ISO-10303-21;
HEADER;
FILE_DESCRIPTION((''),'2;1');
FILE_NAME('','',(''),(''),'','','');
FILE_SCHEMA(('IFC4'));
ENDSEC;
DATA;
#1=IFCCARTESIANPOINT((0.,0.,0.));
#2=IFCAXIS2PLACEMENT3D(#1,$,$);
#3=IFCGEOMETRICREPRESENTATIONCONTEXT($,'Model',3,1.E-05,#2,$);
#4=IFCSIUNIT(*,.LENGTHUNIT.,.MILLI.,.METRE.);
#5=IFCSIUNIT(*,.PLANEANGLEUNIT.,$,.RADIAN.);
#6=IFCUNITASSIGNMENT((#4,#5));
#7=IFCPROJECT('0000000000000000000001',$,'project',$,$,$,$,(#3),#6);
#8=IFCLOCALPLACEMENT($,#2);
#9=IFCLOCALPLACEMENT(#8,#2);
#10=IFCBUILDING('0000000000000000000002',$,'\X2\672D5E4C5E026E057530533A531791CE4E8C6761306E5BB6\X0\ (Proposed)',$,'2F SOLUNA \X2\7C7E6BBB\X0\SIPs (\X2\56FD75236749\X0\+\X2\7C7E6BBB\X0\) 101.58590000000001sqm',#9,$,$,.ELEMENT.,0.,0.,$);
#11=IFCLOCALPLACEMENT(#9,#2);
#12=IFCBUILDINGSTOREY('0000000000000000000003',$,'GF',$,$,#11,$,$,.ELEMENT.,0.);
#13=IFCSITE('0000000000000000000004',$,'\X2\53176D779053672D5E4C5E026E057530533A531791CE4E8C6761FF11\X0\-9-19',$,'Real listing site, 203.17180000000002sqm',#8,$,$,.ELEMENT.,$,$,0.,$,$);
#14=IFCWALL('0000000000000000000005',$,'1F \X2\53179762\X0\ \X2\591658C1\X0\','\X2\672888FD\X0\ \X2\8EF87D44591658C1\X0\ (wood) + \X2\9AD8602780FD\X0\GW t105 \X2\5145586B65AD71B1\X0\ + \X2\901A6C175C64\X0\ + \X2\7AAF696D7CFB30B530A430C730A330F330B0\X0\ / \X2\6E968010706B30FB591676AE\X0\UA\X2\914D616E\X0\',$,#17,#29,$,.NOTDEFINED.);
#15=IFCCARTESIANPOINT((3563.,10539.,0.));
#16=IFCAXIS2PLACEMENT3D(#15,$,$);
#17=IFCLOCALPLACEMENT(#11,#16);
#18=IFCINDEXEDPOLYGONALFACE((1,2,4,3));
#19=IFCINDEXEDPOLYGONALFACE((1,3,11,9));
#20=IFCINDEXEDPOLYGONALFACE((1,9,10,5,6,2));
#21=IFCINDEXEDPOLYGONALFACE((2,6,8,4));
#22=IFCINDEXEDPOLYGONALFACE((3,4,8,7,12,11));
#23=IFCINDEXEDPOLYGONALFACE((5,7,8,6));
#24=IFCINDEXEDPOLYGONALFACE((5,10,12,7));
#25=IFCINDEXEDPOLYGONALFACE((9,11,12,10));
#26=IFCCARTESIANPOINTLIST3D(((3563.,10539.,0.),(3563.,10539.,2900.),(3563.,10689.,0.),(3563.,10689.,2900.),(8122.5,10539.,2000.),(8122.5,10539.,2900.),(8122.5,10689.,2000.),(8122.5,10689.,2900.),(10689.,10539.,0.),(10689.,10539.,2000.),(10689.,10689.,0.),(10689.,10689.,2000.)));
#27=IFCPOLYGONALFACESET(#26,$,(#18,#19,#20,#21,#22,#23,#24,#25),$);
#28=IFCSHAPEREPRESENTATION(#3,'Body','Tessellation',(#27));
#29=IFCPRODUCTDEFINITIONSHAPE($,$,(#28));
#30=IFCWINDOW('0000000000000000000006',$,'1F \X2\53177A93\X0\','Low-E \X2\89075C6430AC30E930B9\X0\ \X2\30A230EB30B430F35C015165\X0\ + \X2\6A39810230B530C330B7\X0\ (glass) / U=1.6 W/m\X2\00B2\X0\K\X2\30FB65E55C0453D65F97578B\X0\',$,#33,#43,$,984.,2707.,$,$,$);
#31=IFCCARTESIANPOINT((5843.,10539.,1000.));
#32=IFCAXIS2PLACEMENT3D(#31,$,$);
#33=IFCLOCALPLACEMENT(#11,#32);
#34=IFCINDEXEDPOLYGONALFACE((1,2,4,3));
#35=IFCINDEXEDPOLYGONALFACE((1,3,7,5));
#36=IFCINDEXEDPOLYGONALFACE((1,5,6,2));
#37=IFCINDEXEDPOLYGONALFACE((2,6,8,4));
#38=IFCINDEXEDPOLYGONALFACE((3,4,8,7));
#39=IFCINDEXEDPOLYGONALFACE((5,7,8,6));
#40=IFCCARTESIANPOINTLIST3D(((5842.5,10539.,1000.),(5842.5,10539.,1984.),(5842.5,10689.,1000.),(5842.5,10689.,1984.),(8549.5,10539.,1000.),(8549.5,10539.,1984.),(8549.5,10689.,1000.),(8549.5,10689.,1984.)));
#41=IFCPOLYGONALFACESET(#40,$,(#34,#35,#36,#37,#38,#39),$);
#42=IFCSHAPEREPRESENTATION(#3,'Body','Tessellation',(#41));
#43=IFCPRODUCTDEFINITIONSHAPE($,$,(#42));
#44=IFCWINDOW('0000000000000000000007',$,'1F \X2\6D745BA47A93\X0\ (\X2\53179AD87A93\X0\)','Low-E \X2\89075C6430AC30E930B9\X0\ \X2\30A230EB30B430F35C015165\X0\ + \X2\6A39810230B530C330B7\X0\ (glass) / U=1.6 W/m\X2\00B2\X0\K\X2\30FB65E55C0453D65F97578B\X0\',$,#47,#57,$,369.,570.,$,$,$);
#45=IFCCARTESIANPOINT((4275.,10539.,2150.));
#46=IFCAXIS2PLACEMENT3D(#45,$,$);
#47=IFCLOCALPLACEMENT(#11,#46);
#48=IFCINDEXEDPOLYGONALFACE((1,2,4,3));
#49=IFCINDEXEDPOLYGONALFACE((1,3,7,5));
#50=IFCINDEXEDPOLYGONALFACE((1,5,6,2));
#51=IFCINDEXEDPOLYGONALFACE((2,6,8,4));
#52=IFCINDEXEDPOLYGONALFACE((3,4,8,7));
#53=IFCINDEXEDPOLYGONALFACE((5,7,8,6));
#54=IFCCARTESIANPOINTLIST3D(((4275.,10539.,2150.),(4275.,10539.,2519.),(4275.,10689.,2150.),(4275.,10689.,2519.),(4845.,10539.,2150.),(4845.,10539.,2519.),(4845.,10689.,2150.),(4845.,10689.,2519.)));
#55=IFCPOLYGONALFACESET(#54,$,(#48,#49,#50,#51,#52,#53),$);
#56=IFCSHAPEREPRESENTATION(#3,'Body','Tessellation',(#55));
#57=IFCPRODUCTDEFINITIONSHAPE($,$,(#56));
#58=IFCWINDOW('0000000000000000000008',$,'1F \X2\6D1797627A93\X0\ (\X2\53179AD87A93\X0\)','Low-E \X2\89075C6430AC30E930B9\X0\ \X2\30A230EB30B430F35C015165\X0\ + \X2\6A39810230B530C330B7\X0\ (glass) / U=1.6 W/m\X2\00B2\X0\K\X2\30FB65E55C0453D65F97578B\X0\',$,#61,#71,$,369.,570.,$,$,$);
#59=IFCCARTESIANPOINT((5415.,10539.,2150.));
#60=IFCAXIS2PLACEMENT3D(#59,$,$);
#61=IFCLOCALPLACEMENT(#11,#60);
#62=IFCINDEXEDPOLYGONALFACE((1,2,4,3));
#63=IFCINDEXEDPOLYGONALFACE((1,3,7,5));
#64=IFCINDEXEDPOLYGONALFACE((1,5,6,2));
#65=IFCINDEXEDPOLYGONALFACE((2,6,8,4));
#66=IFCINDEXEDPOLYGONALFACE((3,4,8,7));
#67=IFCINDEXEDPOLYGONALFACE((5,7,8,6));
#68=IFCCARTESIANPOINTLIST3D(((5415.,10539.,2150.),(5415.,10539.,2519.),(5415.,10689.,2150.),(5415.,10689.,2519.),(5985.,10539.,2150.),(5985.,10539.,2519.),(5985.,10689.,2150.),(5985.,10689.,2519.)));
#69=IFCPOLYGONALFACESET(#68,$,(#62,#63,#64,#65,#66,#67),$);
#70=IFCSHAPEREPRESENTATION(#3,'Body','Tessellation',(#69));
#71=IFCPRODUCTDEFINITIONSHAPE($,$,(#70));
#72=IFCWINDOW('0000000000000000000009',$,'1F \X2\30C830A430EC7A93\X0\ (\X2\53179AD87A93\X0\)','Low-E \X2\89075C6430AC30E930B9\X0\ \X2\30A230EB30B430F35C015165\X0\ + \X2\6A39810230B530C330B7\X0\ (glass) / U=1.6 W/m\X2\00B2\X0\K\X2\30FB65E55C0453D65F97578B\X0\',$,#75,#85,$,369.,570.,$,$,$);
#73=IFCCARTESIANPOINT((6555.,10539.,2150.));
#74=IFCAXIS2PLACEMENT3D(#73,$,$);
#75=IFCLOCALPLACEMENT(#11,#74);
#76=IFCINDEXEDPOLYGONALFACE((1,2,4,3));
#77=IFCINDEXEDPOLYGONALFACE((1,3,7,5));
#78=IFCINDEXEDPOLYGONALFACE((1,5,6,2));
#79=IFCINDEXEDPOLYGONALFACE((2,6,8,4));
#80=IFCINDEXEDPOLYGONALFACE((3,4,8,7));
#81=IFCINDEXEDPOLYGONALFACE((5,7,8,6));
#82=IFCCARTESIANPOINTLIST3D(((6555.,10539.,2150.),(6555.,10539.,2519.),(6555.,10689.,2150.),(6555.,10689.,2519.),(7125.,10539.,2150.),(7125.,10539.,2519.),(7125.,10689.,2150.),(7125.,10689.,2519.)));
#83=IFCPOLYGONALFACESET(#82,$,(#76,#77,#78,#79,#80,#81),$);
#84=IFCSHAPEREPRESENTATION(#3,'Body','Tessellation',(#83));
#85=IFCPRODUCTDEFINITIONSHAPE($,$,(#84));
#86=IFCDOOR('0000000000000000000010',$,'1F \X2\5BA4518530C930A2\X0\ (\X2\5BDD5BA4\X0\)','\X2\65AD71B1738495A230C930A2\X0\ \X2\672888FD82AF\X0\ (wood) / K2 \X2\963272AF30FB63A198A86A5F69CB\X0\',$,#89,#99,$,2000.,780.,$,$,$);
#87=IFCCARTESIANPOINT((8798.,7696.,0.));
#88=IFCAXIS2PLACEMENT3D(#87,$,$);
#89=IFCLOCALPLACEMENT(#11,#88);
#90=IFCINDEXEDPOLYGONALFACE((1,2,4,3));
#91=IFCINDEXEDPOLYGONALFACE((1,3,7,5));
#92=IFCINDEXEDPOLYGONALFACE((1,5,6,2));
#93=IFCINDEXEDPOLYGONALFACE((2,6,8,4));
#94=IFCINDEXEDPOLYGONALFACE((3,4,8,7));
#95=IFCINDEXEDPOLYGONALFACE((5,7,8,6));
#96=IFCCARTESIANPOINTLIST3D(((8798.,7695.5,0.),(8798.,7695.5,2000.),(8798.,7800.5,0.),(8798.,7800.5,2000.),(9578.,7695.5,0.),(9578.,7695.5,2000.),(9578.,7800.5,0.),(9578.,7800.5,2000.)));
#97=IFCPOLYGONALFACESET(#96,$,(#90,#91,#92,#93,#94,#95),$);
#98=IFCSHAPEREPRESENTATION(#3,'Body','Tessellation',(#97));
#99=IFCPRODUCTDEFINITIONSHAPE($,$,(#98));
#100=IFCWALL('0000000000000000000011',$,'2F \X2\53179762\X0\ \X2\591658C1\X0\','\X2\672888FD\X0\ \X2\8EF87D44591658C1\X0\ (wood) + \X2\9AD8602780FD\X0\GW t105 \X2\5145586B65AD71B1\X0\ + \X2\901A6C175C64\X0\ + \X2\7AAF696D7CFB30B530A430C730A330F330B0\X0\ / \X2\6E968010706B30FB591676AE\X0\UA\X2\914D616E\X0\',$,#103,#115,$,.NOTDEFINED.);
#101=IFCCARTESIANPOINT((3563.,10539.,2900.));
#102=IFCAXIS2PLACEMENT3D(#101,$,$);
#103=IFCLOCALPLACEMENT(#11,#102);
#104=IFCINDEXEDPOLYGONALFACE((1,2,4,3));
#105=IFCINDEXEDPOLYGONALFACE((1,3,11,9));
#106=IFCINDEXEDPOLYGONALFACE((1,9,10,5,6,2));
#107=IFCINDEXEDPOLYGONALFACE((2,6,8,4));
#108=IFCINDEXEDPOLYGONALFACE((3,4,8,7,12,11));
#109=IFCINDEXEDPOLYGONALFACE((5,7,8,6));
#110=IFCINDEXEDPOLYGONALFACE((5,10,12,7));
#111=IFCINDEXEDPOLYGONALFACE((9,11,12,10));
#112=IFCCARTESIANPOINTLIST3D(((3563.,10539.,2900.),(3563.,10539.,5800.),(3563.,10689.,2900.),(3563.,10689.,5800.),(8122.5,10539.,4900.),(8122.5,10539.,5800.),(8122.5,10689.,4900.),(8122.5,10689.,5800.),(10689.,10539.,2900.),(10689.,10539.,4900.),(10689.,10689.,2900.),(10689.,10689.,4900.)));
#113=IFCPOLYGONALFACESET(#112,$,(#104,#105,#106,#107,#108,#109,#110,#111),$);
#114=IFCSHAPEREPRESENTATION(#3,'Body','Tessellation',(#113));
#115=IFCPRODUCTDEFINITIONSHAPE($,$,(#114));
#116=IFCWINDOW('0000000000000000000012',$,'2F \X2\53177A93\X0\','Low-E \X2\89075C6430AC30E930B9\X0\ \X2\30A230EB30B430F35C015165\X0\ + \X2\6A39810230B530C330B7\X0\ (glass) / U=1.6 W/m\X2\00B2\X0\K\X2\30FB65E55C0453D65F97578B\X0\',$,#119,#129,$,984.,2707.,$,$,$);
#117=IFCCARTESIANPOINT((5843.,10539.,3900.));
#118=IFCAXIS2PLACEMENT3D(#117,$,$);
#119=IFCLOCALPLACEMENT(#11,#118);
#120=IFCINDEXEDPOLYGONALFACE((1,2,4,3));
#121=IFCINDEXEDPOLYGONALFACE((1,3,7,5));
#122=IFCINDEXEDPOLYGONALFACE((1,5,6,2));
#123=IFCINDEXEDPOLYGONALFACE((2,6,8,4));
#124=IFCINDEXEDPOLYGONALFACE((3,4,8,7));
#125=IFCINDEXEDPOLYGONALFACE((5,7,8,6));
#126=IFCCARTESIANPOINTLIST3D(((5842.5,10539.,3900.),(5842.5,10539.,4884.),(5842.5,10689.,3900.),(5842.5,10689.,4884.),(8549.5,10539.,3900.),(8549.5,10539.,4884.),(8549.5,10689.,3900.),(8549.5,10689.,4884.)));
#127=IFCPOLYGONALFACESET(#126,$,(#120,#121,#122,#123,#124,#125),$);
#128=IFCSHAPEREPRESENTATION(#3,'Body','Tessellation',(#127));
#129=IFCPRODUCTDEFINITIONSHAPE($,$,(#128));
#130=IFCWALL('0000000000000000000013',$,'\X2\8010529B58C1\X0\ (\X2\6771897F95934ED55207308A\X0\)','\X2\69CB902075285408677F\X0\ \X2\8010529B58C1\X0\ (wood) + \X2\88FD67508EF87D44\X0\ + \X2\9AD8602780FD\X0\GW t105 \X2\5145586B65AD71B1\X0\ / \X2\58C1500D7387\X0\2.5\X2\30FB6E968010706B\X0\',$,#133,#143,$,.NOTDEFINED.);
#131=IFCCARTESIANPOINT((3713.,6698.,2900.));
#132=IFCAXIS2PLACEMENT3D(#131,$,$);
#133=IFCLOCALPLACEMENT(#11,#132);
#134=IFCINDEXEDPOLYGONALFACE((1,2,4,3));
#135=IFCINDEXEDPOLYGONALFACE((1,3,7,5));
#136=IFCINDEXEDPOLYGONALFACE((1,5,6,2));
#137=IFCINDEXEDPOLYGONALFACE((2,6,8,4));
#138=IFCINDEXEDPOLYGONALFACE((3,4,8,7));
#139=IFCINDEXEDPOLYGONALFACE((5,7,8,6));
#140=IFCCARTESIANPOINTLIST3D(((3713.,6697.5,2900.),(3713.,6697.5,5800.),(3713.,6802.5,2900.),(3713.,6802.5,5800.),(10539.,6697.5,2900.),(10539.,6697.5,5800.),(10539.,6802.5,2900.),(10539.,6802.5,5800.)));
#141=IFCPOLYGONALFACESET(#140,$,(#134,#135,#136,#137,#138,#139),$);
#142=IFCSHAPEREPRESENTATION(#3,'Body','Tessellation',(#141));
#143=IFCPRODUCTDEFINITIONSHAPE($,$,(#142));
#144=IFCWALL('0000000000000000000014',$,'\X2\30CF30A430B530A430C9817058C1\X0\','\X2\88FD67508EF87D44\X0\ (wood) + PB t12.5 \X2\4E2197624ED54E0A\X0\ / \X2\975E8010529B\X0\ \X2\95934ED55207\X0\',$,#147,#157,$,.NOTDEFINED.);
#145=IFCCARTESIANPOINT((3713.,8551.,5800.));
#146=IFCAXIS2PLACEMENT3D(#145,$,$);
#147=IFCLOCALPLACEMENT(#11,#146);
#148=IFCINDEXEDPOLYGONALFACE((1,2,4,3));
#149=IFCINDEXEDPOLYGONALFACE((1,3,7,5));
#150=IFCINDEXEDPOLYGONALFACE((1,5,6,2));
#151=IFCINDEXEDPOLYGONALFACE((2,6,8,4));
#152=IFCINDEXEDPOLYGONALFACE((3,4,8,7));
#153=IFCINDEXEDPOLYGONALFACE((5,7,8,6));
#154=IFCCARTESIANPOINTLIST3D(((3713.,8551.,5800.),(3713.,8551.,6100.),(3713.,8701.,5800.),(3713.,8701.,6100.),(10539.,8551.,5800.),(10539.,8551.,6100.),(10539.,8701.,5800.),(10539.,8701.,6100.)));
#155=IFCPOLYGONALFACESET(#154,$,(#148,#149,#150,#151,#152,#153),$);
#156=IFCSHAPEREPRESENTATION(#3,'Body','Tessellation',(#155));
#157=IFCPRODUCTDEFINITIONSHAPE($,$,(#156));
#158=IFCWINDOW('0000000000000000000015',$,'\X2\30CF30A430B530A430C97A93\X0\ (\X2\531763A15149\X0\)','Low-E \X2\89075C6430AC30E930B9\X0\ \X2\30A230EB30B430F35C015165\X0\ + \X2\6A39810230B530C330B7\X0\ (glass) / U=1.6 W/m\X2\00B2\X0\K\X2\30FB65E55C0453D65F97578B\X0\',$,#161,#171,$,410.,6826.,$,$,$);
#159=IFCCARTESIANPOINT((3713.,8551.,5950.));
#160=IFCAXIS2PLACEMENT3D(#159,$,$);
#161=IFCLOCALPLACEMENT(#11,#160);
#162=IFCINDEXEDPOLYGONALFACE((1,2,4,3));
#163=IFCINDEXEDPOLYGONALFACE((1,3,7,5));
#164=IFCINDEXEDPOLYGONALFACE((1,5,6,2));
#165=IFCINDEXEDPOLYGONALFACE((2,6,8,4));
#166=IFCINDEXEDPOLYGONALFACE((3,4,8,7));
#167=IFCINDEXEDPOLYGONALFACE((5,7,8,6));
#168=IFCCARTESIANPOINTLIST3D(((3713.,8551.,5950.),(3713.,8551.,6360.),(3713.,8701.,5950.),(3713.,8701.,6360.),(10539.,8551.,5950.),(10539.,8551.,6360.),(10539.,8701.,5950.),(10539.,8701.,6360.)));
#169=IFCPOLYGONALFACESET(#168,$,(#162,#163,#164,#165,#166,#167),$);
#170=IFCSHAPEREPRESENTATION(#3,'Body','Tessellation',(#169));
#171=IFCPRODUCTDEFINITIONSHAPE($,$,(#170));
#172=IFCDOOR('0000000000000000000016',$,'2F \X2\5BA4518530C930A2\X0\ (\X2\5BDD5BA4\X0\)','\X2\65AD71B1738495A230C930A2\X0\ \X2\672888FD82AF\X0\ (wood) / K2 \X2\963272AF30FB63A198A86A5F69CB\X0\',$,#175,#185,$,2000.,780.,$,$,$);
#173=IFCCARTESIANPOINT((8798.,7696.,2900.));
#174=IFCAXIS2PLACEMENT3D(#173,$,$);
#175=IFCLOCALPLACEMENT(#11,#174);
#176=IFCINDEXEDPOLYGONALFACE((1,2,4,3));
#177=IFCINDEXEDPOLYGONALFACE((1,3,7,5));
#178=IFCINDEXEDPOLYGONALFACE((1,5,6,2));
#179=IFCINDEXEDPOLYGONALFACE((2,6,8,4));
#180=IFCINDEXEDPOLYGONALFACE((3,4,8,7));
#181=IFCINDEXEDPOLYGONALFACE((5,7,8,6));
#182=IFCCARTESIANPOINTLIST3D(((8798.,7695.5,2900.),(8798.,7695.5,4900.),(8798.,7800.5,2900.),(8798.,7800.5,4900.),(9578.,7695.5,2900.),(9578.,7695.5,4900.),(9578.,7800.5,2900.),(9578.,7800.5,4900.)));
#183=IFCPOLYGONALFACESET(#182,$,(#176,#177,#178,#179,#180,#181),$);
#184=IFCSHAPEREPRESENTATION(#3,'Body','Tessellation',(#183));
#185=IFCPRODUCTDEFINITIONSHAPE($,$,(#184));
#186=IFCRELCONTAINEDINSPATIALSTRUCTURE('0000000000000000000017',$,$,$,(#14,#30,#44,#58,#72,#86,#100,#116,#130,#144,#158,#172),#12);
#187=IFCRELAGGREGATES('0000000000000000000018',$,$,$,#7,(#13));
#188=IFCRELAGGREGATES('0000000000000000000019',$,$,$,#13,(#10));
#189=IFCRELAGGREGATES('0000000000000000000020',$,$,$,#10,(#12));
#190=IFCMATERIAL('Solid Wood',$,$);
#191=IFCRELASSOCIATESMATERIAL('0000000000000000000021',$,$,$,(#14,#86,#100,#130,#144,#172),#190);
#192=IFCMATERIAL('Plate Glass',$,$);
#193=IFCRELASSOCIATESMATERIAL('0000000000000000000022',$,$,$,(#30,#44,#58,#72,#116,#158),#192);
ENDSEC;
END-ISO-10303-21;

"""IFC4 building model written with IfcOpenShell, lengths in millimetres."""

from ifc_helpers import new_model, si_unit, frame, frame_2d, origin, place, context, project, spatial, rectangle, extrude, material, element, fill, save


model = new_model("IFC4")

# Units and contexts
model_context = context("Model", 3, precision=1e-05, world=origin())
ifc_project = project(units=[si_unit("LENGTHUNIT", "METRE", prefix="MILLI"), si_unit("PLANEANGLEUNIT", "RADIAN")], contexts=[model_context])

# Site, building, storey
site_placement = place(None, origin())
site = spatial("IfcSite", under=ifc_project, at=site_placement, Name="北海道札幌市清田区北野二条１-9-19", ObjectType="Real listing site, 203.17180000000002sqm", CompositionType="ELEMENT", RefElevation=0.0)
building_placement = place(site_placement, origin())
building = spatial("IfcBuilding", under=site, at=building_placement, Name="札幌市清田区北野二条の家 (Proposed)", ObjectType="2F SOLUNA 籾殻SIPs (国産杉+籾殻) 101.58590000000001sqm", CompositionType="ELEMENT", ElevationOfRefHeight=0.0, ElevationOfTerrain=0.0)
storey_placement = place(building_placement, origin())
storey = spatial("IfcBuildingStorey", under=building, at=storey_placement, Name="GF", CompositionType="ELEMENT", Elevation=0.0)

# Wall, openings, windows
ifc_material_1 = material(Name="Solid Wood")
wall_1_placement = place(storey_placement, frame((3563.0, 10539.0, 0.0)))
wall_1 = element("IfcWall", 1, at=wall_1_placement, inside=storey, material=ifc_material_1, Name="1F 北面 外壁", Description="木製 軸組外壁 (wood) + 高性能GW t105 充填断熱 + 通気層 + 窯業系サイディング / 準耐火・外皮UA配慮", PredefinedType="NOTDEFINED", context=model_context, shape_type="SweptSolid", body=[
    extrude(rectangle(XDim=7126.0, YDim=150.0, at=frame_2d((3563.0, 75.0))), frame((3563.0, 10539.0, 0.0)), (0.0, 0.0, 1.0), 2900.0),
])
opening_1_placement = place(storey_placement, frame((5843.0, 10539.0, 1000.0)))
opening_1 = element("IfcOpeningElement", 2, at=opening_1_placement, cuts=wall_1, PredefinedType="NOTDEFINED", context=model_context, shape_type="SweptSolid", body=[
    extrude(rectangle(XDim=2707.0, YDim=150.0, at=frame_2d((1353.0, 75.0))), frame((5843.0, 10539.0, 1000.0)), (0.0, 0.0, 1.0), 984.0),
])
opening_2_placement = place(storey_placement, frame((4275.0, 10539.0, 2150.0)))
opening_2 = element("IfcOpeningElement", 3, at=opening_2_placement, cuts=wall_1, PredefinedType="NOTDEFINED", context=model_context, shape_type="SweptSolid", body=[
    extrude(rectangle(XDim=570.0, YDim=150.0, at=frame_2d((285.0, 75.0))), frame((4275.0, 10539.0, 2150.0)), (0.0, 0.0, 1.0), 369.0),
])
opening_3_placement = place(storey_placement, frame((5415.0, 10539.0, 2150.0)))
opening_3 = element("IfcOpeningElement", 4, at=opening_3_placement, cuts=wall_1, PredefinedType="NOTDEFINED", context=model_context, shape_type="SweptSolid", body=[
    extrude(rectangle(XDim=570.0, YDim=150.0, at=frame_2d((285.0, 75.0))), frame((5415.0, 10539.0, 2150.0)), (0.0, 0.0, 1.0), 369.0),
])
opening_4_placement = place(storey_placement, frame((6555.0, 10539.0, 2150.0)))
opening_4 = element("IfcOpeningElement", 5, at=opening_4_placement, cuts=wall_1, PredefinedType="NOTDEFINED", context=model_context, shape_type="SweptSolid", body=[
    extrude(rectangle(XDim=570.0, YDim=150.0, at=frame_2d((285.0, 75.0))), frame((6555.0, 10539.0, 2150.0)), (0.0, 0.0, 1.0), 369.0),
])
ifc_material_2 = material(Name="Plate Glass")
window_1_placement = place(storey_placement, frame((5843.0, 10539.0, 1000.0)))
window_1 = element("IfcWindow", 6, at=window_1_placement, inside=storey, material=ifc_material_2, Name="1F 北窓", Description="Low-E 複層ガラス アルゴン封入 + 樹脂サッシ (glass) / U=1.6 W/m²K・日射取得型", OverallHeight=984.0, OverallWidth=2707.0, context=model_context, shape_type="SweptSolid", body=[
    extrude(rectangle(XDim=2707.0, YDim=150.0, at=frame_2d((1353.0, 75.0))), frame((5843.0, 10539.0, 1000.0)), (0.0, 0.0, 1.0), 984.0),
])
fill(opening_1, window_1)
window_2_placement = place(storey_placement, frame((4275.0, 10539.0, 2150.0)))
window_2 = element("IfcWindow", 7, at=window_2_placement, inside=storey, material=ifc_material_2, Name="1F 浴室窓 (北高窓)", Description="Low-E 複層ガラス アルゴン封入 + 樹脂サッシ (glass) / U=1.6 W/m²K・日射取得型", OverallHeight=369.0, OverallWidth=570.0, context=model_context, shape_type="SweptSolid", body=[
    extrude(rectangle(XDim=570.0, YDim=150.0, at=frame_2d((285.0, 75.0))), frame((4275.0, 10539.0, 2150.0)), (0.0, 0.0, 1.0), 369.0),
])
fill(opening_2, window_2)
window_3_placement = place(storey_placement, frame((5415.0, 10539.0, 2150.0)))
window_3 = element("IfcWindow", 8, at=window_3_placement, inside=storey, material=ifc_material_2, Name="1F 洗面窓 (北高窓)", Description="Low-E 複層ガラス アルゴン封入 + 樹脂サッシ (glass) / U=1.6 W/m²K・日射取得型", OverallHeight=369.0, OverallWidth=570.0, context=model_context, shape_type="SweptSolid", body=[
    extrude(rectangle(XDim=570.0, YDim=150.0, at=frame_2d((285.0, 75.0))), frame((5415.0, 10539.0, 2150.0)), (0.0, 0.0, 1.0), 369.0),
])
fill(opening_3, window_3)
window_4_placement = place(storey_placement, frame((6555.0, 10539.0, 2150.0)))
window_4 = element("IfcWindow", 9, at=window_4_placement, inside=storey, material=ifc_material_2, Name="1F トイレ窓 (北高窓)", Description="Low-E 複層ガラス アルゴン封入 + 樹脂サッシ (glass) / U=1.6 W/m²K・日射取得型", OverallHeight=369.0, OverallWidth=570.0, context=model_context, shape_type="SweptSolid", body=[
    extrude(rectangle(XDim=570.0, YDim=150.0, at=frame_2d((285.0, 75.0))), frame((6555.0, 10539.0, 2150.0)), (0.0, 0.0, 1.0), 369.0),
])
fill(opening_4, window_4)

# Door
door_1_placement = place(storey_placement, frame((8798.0, 7696.0, 0.0)))
element("IfcDoor", 10, at=door_1_placement, inside=storey, material=ifc_material_1, Name="1F 室内ドア (寝室)", Description="断熱玄関ドア 木製芯 (wood) / K2 防犯・採風機構", OverallHeight=2000.0, OverallWidth=780.0, context=model_context, shape_type="SweptSolid", body=[
    extrude(rectangle(XDim=780.0, YDim=105.0, at=frame_2d((390.0, 52.0))), frame((8798.0, 7696.0, 0.0)), (0.0, 0.0, 1.0), 2000.0),
])

# Wall, opening, window
wall_2_placement = place(storey_placement, frame((3563.0, 10539.0, 2900.0)))
wall_2 = element("IfcWall", 11, at=wall_2_placement, inside=storey, material=ifc_material_1, Name="2F 北面 外壁", Description="木製 軸組外壁 (wood) + 高性能GW t105 充填断熱 + 通気層 + 窯業系サイディング / 準耐火・外皮UA配慮", PredefinedType="NOTDEFINED", context=model_context, shape_type="SweptSolid", body=[
    extrude(rectangle(XDim=7126.0, YDim=150.0, at=frame_2d((3563.0, 75.0))), frame((3563.0, 10539.0, 2900.0)), (0.0, 0.0, 1.0), 2900.0),
])
opening_5_placement = place(storey_placement, frame((5843.0, 10539.0, 3900.0)))
opening_5 = element("IfcOpeningElement", 12, at=opening_5_placement, cuts=wall_2, PredefinedType="NOTDEFINED", context=model_context, shape_type="SweptSolid", body=[
    extrude(rectangle(XDim=2707.0, YDim=150.0, at=frame_2d((1353.0, 75.0))), frame((5843.0, 10539.0, 3900.0)), (0.0, 0.0, 1.0), 984.0),
])
window_5_placement = place(storey_placement, frame((5843.0, 10539.0, 3900.0)))
window_5 = element("IfcWindow", 13, at=window_5_placement, inside=storey, material=ifc_material_2, Name="2F 北窓", Description="Low-E 複層ガラス アルゴン封入 + 樹脂サッシ (glass) / U=1.6 W/m²K・日射取得型", OverallHeight=984.0, OverallWidth=2707.0, context=model_context, shape_type="SweptSolid", body=[
    extrude(rectangle(XDim=2707.0, YDim=150.0, at=frame_2d((1353.0, 75.0))), frame((5843.0, 10539.0, 3900.0)), (0.0, 0.0, 1.0), 984.0),
])
fill(opening_5, window_5)

# Wall
wall_3_placement = place(storey_placement, frame((3713.0, 6698.0, 2900.0)))
element("IfcWall", 14, at=wall_3_placement, inside=storey, material=ifc_material_1, Name="耐力壁 (東西間仕切り)", Description="構造用合板 耐力壁 (wood) + 製材軸組 + 高性能GW t105 充填断熱 / 壁倍率2.5・準耐火", PredefinedType="NOTDEFINED", context=model_context, shape_type="SweptSolid", body=[
    extrude(rectangle(XDim=6826.0, YDim=105.0, at=frame_2d((3413.0, 52.0))), frame((3713.0, 6698.0, 2900.0)), (0.0, 0.0, 1.0), 2900.0),
])

# Wall, opening, window
wall_4_placement = place(storey_placement, frame((3713.0, 8551.0, 5800.0)))
wall_4 = element("IfcWall", 15, at=wall_4_placement, inside=storey, material=ifc_material_1, Name="ハイサイド腰壁", Description="製材軸組 (wood) + PB t12.5 両面仕上 / 非耐力 間仕切", PredefinedType="NOTDEFINED", context=model_context, shape_type="SweptSolid", body=[
    extrude(rectangle(XDim=6826.0, YDim=150.0, at=frame_2d((3413.0, 75.0))), frame((3713.0, 8551.0, 5800.0)), (0.0, 0.0, 1.0), 700.0),
])
opening_6_placement = place(storey_placement, frame((3713.0, 8551.0, 5950.0)))
opening_6 = element("IfcOpeningElement", 16, at=opening_6_placement, cuts=wall_4, PredefinedType="NOTDEFINED", context=model_context, shape_type="SweptSolid", body=[
    extrude(rectangle(XDim=6826.0, YDim=150.0, at=frame_2d((3413.0, 75.0))), frame((3713.0, 8551.0, 5950.0)), (0.0, 0.0, 1.0), 410.0),
])
window_6_placement = place(storey_placement, frame((3713.0, 8551.0, 5950.0)))
window_6 = element("IfcWindow", 17, at=window_6_placement, inside=storey, material=ifc_material_2, Name="ハイサイド窓 (北採光)", Description="Low-E 複層ガラス アルゴン封入 + 樹脂サッシ (glass) / U=1.6 W/m²K・日射取得型", OverallHeight=410.0, OverallWidth=6826.0, context=model_context, shape_type="SweptSolid", body=[
    extrude(rectangle(XDim=6826.0, YDim=150.0, at=frame_2d((3413.0, 75.0))), frame((3713.0, 8551.0, 5950.0)), (0.0, 0.0, 1.0), 410.0),
])
fill(opening_6, window_6)

# Door
door_2_placement = place(storey_placement, frame((8798.0, 7696.0, 2900.0)))
element("IfcDoor", 18, at=door_2_placement, inside=storey, material=ifc_material_1, Name="2F 室内ドア (寝室)", Description="断熱玄関ドア 木製芯 (wood) / K2 防犯・採風機構", OverallHeight=2000.0, OverallWidth=780.0, context=model_context, shape_type="SweptSolid", body=[
    extrude(rectangle(XDim=780.0, YDim=105.0, at=frame_2d((390.0, 52.0))), frame((8798.0, 7696.0, 2900.0)), (0.0, 0.0, 1.0), 2000.0),
])

save(model, "model.ifc")
